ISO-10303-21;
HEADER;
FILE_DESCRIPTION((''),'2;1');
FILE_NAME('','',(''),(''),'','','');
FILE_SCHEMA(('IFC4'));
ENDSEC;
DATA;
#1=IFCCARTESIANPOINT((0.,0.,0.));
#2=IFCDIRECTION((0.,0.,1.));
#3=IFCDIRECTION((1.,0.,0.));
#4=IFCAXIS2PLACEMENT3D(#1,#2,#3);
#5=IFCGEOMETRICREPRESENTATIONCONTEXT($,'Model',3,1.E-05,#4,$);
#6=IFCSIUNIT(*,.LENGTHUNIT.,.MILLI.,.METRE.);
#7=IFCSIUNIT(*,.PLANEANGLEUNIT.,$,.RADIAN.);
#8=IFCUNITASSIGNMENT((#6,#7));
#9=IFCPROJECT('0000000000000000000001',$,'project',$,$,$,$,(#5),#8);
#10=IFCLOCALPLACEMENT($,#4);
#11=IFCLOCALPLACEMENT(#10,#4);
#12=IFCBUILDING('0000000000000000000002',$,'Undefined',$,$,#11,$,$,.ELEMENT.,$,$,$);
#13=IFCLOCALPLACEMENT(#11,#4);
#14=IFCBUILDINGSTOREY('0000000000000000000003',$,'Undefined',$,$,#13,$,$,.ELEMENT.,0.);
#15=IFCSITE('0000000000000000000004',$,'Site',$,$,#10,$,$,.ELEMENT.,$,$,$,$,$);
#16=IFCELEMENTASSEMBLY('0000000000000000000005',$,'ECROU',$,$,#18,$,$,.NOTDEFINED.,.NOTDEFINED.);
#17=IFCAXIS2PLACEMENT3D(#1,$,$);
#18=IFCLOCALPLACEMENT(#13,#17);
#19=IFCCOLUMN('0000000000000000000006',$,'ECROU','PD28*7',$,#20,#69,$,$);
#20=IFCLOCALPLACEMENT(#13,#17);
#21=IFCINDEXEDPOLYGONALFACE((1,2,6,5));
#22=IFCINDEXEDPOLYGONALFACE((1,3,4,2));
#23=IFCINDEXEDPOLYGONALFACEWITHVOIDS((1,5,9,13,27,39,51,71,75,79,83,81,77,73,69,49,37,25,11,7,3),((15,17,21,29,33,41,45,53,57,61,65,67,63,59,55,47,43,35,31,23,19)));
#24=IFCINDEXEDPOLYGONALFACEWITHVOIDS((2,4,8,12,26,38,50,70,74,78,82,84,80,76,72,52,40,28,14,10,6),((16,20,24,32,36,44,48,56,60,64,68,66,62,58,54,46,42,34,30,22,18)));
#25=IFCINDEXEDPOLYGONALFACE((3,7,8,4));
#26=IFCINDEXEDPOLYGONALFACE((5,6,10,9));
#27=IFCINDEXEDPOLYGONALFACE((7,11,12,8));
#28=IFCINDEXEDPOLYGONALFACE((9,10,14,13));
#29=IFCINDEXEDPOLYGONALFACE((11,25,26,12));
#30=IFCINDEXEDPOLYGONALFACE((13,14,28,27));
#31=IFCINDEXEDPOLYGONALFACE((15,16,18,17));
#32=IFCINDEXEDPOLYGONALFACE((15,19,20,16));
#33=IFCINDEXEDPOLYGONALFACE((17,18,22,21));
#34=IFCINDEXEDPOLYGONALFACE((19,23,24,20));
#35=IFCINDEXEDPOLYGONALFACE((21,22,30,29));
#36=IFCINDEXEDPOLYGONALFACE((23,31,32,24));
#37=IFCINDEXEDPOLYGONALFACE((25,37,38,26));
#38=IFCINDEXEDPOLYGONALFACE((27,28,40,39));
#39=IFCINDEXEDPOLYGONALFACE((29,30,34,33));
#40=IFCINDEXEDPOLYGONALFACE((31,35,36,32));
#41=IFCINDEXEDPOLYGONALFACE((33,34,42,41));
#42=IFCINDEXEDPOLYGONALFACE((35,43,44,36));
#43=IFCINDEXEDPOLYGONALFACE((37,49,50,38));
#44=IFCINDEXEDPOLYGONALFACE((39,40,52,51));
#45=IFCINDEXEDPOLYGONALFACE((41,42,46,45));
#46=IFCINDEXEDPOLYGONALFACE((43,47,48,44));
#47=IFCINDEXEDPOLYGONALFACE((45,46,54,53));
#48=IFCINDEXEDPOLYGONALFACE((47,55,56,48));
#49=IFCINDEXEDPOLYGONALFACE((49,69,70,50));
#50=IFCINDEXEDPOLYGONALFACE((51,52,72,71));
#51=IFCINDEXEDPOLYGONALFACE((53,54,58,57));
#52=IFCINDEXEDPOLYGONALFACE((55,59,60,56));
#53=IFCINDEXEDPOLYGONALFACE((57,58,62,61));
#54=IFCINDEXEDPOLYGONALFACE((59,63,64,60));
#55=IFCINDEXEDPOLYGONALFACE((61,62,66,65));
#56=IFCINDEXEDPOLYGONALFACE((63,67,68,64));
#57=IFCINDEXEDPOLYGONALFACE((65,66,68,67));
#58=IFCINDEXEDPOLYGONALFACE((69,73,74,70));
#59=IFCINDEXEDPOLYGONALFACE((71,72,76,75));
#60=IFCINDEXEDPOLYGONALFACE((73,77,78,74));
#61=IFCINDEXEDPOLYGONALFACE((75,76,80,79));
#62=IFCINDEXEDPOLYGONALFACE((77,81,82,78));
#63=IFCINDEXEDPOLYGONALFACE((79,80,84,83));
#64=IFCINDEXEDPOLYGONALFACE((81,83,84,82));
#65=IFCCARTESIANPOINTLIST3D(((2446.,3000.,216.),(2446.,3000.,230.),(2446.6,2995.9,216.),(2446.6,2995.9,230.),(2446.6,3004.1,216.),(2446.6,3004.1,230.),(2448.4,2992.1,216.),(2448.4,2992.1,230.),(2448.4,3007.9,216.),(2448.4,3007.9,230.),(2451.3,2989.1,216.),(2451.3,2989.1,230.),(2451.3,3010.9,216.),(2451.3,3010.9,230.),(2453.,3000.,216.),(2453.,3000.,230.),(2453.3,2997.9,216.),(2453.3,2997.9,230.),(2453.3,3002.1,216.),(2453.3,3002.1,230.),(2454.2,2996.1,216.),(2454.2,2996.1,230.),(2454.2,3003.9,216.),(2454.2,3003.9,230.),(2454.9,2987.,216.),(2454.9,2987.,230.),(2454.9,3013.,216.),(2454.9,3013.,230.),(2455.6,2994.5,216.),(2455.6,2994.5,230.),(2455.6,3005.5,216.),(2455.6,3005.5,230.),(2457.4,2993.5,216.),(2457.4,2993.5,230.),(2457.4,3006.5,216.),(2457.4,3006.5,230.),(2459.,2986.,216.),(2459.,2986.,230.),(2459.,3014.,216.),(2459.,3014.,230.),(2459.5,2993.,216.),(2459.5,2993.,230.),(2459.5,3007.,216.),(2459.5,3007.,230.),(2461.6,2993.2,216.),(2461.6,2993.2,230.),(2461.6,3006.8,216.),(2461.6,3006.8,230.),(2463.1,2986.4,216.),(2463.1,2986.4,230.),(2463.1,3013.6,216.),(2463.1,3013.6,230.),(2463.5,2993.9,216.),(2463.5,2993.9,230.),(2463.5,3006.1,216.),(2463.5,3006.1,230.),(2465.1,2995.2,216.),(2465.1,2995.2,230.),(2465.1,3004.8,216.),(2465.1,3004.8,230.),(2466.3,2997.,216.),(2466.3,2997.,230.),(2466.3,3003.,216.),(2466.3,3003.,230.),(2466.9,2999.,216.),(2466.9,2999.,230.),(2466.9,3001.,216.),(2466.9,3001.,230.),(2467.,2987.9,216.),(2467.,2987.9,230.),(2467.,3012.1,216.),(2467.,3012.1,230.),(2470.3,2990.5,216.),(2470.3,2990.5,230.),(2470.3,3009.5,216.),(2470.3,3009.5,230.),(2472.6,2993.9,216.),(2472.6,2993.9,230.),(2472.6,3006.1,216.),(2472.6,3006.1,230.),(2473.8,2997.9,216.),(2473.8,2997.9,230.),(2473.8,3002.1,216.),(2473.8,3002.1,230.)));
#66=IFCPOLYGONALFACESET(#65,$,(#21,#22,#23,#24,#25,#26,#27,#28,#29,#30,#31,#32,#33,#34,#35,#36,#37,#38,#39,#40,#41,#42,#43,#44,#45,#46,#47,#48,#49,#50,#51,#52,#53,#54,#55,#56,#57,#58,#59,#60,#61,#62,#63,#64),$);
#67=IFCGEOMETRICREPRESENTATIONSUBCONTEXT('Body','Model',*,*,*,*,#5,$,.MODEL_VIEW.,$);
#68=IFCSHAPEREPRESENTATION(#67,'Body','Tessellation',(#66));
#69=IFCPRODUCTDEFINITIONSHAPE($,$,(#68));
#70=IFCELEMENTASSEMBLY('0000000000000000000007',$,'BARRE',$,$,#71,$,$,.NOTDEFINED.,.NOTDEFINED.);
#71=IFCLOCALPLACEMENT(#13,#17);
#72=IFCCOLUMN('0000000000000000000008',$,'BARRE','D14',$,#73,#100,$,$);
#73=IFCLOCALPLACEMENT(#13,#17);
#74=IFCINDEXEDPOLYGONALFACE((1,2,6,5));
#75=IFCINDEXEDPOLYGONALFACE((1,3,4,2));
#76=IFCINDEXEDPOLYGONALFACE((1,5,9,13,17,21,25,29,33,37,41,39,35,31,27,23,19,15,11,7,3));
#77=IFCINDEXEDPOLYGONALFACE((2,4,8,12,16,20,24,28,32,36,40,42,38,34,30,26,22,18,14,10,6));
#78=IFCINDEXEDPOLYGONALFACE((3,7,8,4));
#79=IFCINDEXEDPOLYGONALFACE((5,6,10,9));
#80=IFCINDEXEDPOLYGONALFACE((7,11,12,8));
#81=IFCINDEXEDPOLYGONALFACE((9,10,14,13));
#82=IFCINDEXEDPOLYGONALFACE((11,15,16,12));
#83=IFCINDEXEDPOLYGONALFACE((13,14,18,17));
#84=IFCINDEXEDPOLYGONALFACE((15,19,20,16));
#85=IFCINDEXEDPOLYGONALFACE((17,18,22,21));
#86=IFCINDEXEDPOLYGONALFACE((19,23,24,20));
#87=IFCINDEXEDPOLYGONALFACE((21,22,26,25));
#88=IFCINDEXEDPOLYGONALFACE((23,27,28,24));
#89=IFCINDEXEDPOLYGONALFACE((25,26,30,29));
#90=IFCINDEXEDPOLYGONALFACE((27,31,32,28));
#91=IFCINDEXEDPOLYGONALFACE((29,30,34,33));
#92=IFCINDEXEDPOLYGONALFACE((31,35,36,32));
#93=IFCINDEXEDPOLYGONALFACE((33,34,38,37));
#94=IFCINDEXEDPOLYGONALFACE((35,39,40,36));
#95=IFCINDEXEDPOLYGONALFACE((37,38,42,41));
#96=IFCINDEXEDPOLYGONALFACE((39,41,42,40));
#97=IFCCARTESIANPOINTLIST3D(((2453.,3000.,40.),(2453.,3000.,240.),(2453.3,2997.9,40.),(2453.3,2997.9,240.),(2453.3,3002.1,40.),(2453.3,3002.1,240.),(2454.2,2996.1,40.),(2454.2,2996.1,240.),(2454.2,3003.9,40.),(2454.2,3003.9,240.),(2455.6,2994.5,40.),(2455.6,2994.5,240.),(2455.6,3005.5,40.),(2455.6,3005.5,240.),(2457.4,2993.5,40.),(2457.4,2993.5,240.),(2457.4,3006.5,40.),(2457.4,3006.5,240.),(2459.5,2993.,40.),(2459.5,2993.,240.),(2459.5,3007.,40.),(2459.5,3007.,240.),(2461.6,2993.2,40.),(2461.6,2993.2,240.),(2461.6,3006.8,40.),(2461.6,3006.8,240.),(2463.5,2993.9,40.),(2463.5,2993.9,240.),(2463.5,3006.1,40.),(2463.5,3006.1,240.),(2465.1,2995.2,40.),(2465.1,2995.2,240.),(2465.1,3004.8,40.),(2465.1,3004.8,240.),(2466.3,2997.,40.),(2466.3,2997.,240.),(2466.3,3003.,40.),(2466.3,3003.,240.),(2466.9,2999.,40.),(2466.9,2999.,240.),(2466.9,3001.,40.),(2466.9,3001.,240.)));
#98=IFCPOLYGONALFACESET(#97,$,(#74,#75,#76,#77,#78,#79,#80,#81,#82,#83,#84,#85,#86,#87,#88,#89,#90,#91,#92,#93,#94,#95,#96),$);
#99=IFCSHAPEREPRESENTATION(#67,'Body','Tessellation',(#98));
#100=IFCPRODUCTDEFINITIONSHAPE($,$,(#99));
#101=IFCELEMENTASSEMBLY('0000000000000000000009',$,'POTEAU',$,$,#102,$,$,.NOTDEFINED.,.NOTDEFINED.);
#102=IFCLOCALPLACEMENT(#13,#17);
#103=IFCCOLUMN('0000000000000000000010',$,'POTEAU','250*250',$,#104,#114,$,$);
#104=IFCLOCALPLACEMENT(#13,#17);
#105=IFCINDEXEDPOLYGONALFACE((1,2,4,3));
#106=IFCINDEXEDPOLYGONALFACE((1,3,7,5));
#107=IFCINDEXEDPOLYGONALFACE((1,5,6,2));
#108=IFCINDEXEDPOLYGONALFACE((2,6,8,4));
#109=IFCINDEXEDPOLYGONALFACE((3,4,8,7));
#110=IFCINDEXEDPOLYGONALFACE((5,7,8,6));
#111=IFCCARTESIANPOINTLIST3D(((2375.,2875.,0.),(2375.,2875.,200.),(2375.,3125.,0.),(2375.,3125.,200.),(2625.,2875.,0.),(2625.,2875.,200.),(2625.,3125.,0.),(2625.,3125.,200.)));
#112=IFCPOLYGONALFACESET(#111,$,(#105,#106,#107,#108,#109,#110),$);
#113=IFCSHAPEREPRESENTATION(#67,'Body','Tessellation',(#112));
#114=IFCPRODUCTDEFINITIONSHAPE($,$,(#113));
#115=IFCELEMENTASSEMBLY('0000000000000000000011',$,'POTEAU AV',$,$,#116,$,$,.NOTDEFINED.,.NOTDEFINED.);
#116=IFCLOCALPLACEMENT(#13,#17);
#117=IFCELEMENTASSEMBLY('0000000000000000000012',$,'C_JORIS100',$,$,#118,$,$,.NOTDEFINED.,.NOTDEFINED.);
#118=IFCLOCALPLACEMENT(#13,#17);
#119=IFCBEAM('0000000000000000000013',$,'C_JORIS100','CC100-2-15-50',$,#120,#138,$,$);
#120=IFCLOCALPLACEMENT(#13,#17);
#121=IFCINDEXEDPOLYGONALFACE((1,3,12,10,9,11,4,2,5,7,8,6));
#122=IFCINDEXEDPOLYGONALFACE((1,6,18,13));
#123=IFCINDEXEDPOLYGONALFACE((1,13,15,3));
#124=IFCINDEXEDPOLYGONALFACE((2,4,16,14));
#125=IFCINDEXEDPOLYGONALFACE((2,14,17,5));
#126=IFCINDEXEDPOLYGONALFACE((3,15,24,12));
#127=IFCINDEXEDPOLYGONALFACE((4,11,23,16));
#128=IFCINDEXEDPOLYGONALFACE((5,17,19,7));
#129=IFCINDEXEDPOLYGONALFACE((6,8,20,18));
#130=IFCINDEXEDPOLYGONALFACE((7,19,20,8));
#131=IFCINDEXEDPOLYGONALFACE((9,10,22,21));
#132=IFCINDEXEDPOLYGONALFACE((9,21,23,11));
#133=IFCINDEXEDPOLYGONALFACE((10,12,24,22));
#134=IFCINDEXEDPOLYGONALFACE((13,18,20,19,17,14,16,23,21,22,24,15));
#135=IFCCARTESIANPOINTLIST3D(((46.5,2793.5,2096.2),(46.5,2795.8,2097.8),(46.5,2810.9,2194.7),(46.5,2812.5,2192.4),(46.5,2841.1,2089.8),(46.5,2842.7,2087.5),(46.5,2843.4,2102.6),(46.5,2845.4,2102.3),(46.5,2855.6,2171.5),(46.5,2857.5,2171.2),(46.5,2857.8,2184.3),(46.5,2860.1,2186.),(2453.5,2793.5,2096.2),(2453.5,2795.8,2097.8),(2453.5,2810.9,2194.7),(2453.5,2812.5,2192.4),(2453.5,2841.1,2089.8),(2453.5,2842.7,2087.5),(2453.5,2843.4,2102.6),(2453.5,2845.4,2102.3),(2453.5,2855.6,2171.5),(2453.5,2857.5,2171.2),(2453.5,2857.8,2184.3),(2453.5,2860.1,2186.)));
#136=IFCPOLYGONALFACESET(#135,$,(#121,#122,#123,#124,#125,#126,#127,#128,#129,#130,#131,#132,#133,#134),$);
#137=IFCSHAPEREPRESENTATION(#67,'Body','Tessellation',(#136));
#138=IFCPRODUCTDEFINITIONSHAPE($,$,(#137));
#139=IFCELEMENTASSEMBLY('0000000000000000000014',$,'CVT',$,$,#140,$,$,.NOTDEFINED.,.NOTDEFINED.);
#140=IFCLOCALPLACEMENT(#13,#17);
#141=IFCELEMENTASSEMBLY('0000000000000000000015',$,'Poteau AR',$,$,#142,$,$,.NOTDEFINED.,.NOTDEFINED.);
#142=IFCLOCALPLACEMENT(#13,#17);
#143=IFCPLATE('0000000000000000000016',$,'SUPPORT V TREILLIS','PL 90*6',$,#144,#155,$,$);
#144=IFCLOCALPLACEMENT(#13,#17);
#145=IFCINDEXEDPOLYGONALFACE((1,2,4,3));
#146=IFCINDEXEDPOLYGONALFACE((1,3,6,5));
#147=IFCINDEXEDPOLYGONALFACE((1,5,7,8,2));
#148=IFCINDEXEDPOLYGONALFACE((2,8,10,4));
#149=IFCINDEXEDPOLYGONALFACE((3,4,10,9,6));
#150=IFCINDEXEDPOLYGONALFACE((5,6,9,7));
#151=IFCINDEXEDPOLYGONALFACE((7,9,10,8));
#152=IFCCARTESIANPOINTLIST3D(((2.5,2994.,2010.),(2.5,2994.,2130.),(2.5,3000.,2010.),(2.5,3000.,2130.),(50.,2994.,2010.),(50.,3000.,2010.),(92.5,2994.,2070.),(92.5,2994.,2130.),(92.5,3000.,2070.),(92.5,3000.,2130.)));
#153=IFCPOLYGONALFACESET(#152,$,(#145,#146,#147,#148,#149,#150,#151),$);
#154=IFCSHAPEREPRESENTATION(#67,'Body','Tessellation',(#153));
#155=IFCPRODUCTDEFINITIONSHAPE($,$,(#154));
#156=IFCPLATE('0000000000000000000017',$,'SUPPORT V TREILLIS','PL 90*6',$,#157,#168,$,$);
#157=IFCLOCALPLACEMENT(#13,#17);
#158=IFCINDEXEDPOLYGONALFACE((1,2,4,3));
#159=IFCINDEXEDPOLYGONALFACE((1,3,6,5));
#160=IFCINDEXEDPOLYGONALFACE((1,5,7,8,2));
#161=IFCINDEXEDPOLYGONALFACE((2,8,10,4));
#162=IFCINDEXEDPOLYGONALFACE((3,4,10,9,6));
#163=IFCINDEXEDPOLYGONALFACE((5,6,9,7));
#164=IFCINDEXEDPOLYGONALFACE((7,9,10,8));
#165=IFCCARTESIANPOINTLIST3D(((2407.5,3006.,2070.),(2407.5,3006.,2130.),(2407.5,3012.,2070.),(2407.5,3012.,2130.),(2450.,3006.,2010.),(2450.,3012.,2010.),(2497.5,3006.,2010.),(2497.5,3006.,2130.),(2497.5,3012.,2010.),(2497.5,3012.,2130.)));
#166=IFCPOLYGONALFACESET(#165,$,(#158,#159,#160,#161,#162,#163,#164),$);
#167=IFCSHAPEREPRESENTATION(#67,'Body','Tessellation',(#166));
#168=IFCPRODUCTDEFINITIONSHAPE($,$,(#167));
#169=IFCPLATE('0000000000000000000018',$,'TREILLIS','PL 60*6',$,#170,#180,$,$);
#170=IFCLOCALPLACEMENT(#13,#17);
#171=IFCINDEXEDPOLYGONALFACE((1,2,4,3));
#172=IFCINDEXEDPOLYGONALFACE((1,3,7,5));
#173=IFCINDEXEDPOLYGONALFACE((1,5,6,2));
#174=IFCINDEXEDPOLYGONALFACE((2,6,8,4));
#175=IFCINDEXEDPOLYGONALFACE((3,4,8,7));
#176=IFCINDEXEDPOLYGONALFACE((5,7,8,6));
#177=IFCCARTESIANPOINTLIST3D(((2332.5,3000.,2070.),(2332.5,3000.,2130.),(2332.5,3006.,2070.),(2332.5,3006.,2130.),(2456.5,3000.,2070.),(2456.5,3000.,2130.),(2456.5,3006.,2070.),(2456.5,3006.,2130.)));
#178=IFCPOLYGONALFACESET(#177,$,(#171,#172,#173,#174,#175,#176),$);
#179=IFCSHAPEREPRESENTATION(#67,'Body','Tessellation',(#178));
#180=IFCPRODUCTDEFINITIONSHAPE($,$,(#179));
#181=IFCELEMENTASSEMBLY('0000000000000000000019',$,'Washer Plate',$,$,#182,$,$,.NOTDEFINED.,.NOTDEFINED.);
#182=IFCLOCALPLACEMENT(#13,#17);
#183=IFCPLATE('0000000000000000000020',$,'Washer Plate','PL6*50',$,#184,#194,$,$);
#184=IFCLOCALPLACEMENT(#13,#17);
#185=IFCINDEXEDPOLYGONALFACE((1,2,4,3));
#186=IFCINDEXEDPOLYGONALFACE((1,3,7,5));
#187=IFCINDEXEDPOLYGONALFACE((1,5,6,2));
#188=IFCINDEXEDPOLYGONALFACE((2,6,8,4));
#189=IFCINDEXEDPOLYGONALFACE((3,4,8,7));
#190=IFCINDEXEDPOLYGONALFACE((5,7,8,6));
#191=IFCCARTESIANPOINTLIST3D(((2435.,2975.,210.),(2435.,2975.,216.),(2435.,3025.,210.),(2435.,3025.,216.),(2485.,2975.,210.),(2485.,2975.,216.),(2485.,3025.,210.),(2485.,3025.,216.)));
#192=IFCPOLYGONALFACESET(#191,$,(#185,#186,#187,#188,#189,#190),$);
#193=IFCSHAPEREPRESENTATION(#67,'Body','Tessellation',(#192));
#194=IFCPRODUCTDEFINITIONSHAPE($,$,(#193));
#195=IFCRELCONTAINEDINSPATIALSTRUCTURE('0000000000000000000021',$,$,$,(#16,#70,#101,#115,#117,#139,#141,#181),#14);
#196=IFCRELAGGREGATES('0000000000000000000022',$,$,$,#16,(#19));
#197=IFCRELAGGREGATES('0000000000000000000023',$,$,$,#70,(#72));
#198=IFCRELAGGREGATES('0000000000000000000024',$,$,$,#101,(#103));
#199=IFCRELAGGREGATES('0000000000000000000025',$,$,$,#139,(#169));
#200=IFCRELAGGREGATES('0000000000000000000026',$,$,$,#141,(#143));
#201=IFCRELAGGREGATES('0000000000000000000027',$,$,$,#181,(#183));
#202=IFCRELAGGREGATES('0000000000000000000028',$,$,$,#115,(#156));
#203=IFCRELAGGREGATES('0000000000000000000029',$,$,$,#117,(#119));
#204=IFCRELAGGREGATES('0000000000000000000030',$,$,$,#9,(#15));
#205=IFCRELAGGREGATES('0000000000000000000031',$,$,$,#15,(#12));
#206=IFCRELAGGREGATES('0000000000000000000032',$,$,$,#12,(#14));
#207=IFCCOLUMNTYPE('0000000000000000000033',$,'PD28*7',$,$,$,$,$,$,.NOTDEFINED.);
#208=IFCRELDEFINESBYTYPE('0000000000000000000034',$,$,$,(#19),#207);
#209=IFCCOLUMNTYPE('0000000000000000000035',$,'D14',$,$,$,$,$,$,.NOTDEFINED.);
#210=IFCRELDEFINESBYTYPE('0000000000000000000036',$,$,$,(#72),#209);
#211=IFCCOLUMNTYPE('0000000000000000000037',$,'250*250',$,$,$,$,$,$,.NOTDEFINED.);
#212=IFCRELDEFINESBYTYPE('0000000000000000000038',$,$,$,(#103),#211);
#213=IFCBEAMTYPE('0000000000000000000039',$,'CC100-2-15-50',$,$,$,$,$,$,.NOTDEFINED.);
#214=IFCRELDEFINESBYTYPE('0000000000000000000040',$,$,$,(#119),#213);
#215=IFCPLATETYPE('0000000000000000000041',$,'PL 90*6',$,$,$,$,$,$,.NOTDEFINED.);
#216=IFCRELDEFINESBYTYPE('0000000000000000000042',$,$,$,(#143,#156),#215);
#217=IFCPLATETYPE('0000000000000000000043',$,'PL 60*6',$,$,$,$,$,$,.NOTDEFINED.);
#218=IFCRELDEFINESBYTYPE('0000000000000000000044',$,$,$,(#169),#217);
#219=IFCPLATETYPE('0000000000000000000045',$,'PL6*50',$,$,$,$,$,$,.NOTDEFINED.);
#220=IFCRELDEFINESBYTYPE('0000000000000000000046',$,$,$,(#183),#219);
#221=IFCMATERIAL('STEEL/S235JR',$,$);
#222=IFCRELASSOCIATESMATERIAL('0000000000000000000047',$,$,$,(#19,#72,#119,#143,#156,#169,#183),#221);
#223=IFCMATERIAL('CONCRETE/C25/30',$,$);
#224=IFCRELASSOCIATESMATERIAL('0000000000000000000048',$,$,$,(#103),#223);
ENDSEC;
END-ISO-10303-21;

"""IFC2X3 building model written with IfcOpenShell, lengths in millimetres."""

from ifc_helpers import new_model, si_unit, frame, origin_with_axes, origin_2d_with_axis, place, context, subcontext, project, spatial, polyline, rectangle, circle, hollow_circle, c_section, outline, extrude, clip, halfspace, material, type_object, element, aggregate, save


model = new_model("IFC2X3")

# Units and contexts
model_context = context("Model", 3, precision=1e-05, world=origin_with_axes())
body_context = subcontext(model_context, "Body", "Model", "MODEL_VIEW")
ifc_project = project(units=[si_unit("LENGTHUNIT", "METRE", prefix="MILLI"), si_unit("PLANEANGLEUNIT", "RADIAN")], contexts=[model_context])

# Site, building, storey
site_placement = place(None, origin_with_axes())
site = spatial("IfcSite", under=ifc_project, at=site_placement, Name="Site", CompositionType="ELEMENT")
building_placement = place(site_placement, origin_with_axes())
building = spatial("IfcBuilding", under=site, at=building_placement, Name="Undefined", CompositionType="ELEMENT")
storey_placement = place(building_placement, origin_with_axes())
storey = spatial("IfcBuildingStorey", under=building, at=storey_placement, Name="Undefined", CompositionType="ELEMENT", Elevation=0.0)

# Element assemblies, columns
assembly_1_placement = place(storey_placement, origin_with_axes())
assembly_1 = element("IfcElementAssembly", 1, at=assembly_1_placement, inside=storey, Name="ECROU", AssemblyPlace="NOTDEFINED", PredefinedType="NOTDEFINED")
ifc_material_1 = material(Name="STEEL/S235JR")
column_type_1 = type_object("IfcColumnType", Name="PD28*7", PredefinedType="NOTDEFINED")
column_1_placement = place(assembly_1_placement, frame((2460.0, 3000.0, 230.0), z_axis=(0.0, 0.0, -1.0), x_axis=(0.0, -1.0, 0.0)))
column_1 = element("IfcColumn", 2, at=column_1_placement, type_object=column_type_1, material=ifc_material_1, Name="ECROU", Description="PD28*7", context=body_context, shape_type="SweptSolid", body=[
    extrude(hollow_circle(Radius=14.0, WallThickness=7.0, at=origin_2d_with_axis()), frame((0.0, 0.0, 14.0), z_axis=(0.0, 0.0, -1.0), x_axis=(0.0, 1.0, 0.0)), (0.0, 0.0, 1.0), 14.0),
])
aggregate(assembly_1, [column_1])
assembly_2_placement = place(storey_placement, origin_with_axes())
assembly_2 = element("IfcElementAssembly", 3, at=assembly_2_placement, inside=storey, Name="BARRE", AssemblyPlace="NOTDEFINED", PredefinedType="NOTDEFINED")
column_type_2 = type_object("IfcColumnType", Name="D14", PredefinedType="NOTDEFINED")
column_2_placement = place(assembly_2_placement, frame((2460.0, 3000.0, 240.0), z_axis=(0.0, 0.0, -1.0), x_axis=(0.0, -1.0, 0.0)))
column_2 = element("IfcColumn", 4, at=column_2_placement, type_object=column_type_2, material=ifc_material_1, Name="BARRE", Description="D14", context=body_context, shape_type="SweptSolid", body=[
    extrude(circle(Radius=7.0, at=origin_2d_with_axis()), frame((0.0, 0.0, 200.0), z_axis=(0.0, 0.0, -1.0), x_axis=(0.0, 1.0, 0.0)), (0.0, 0.0, 1.0), 200.0),
])
aggregate(assembly_2, [column_2])
assembly_3_placement = place(storey_placement, origin_with_axes())
assembly_3 = element("IfcElementAssembly", 5, at=assembly_3_placement, inside=storey, Name="POTEAU", AssemblyPlace="NOTDEFINED", PredefinedType="NOTDEFINED")
ifc_material_2 = material(Name="CONCRETE/C25/30")
column_type_3 = type_object("IfcColumnType", Name="250*250", PredefinedType="NOTDEFINED")
column_3_placement = place(assembly_3_placement, frame((2500.0, 3000.0, 0.0), z_axis=(0.0, 0.0, 1.0), x_axis=(0.0, 1.0, 0.0)))
column_3 = element("IfcColumn", 6, at=column_3_placement, type_object=column_type_3, material=ifc_material_2, Name="POTEAU", Description="250*250", context=body_context, shape_type="SweptSolid", body=[
    extrude(rectangle(XDim=250.0, YDim=250.0, at=origin_2d_with_axis()), frame((0.0, 0.0, 200.0), z_axis=(0.0, 0.0, -1.0), x_axis=(0.0, 1.0, 0.0)), (0.0, 0.0, 1.0), 200.0),
])
aggregate(assembly_3, [column_3])
assembly_4_placement = place(storey_placement, origin_with_axes())
assembly_4 = element("IfcElementAssembly", 7, at=assembly_4_placement, inside=storey, Name="POTEAU AV", AssemblyPlace="NOTDEFINED", PredefinedType="NOTDEFINED")

# Element assemblies, beam
assembly_5_placement = place(storey_placement, origin_with_axes())
assembly_5 = element("IfcElementAssembly", 8, at=assembly_5_placement, inside=storey, Name="C_JORIS100", AssemblyPlace="NOTDEFINED", PredefinedType="NOTDEFINED")
beam_type_1 = type_object("IfcBeamType", Name="CC100-2-15-50", PredefinedType="NOTDEFINED")
beam_1_placement = place(assembly_5_placement, frame((2500.0, 2826.8, 2141.1), z_axis=(0.0, 0.173992, 0.984747), x_axis=(-1.0, 0.0, 0.0)))
beam_1 = element("IfcBeam", 9, at=beam_1_placement, type_object=beam_type_1, material=ifc_material_1, Name="C_JORIS100", Description="CC100-2-15-50", context=body_context, shape_type="Clipping", body=[
    clip(clip(extrude(c_section(Depth=100.0, Width=50.0, WallThickness=2.0, Girth=15.0, at=origin_2d_with_axis()), frame((2500.0, 0.0, 0.0), z_axis=(-1.0, 0.0, 0.0), x_axis=(0.0, -1.0, 0.0)), (0.0, 0.0, 1.0), 2500.0), halfspace(frame((2453.5, 23.9, 50.0), z_axis=(1.0, 0.0, 0.0), x_axis=(0.0, 0.000028, -1.0)), False)), halfspace(frame((46.5, 23.0, 50.0), z_axis=(-1.0, 0.0, 0.0), x_axis=(0.0, 0.000028, -1.0)), False)),
])
assembly_6_placement = place(storey_placement, origin_with_axes())
assembly_6 = element("IfcElementAssembly", 10, at=assembly_6_placement, inside=storey, Name="CVT", AssemblyPlace="NOTDEFINED", PredefinedType="NOTDEFINED")

# Element assembly, plate
assembly_7_placement = place(storey_placement, origin_with_axes())
assembly_7 = element("IfcElementAssembly", 11, at=assembly_7_placement, inside=storey, Name="Poteau AR", AssemblyPlace="NOTDEFINED", PredefinedType="NOTDEFINED")
plate_type_1 = type_object("IfcPlateType", Name="PL 90*6", PredefinedType="NOTDEFINED")
plate_1_placement = place(assembly_7_placement, frame((47.5, 2997.0, 2130.0), z_axis=(0.0, -1.0, 0.0), x_axis=(0.0, 0.0, -1.0)))
plate_1 = element("IfcPlate", 12, at=plate_1_placement, type_object=plate_type_1, material=ifc_material_1, Name="SUPPORT V TREILLIS", Description="PL 90*6", context=body_context, shape_type="Clipping", body=[
    clip(extrude(outline(polyline([(120.0, -45.0), (0.0, -45.0), (0.0, 45.0), (60.0, 45.0), (120.0, 2.5), (120.0, -45.0)])), frame((0.0, 0.0, -3.0), z_axis=(0.0, 0.0, 1.0), x_axis=(1.0, 0.0, 0.0)), (0.0, 0.0, 1.0), 6.0), halfspace(frame((187.1, -45.0, 3.0), z_axis=(0.578017, 0.816024, 0.0), x_axis=(-0.816024, 0.578017, 0.0)), False)),
])

# Plates
plate_2_placement = place(assembly_4_placement, frame((2452.5, 3009.0, 2130.0), z_axis=(0.0, 1.0, 0.0), x_axis=(0.0, 0.0, -1.0)))
plate_2 = element("IfcPlate", 13, at=plate_2_placement, type_object=plate_type_1, material=ifc_material_1, Name="SUPPORT V TREILLIS", Description="PL 90*6", context=body_context, shape_type="Clipping", body=[
    clip(extrude(outline(polyline([(120.0, 2.5), (120.0, -45.0), (0.0, -45.0), (0.0, 45.0), (60.0, 45.0), (120.0, 2.5)])), frame((0.0, 0.0, -3.0), z_axis=(0.0, 0.0, 1.0), x_axis=(1.0, 0.0, 0.0)), (0.0, 0.0, 1.0), 6.0), halfspace(frame((187.1, -45.0, 3.0), z_axis=(0.578017, 0.816024, 0.0), x_axis=(-0.816024, 0.578017, 0.0)), False)),
])
plate_type_2 = type_object("IfcPlateType", Name="PL 60*6", PredefinedType="NOTDEFINED")
plate_3_placement = place(assembly_6_placement, frame((2456.5, 3003.0, 2100.0), z_axis=(0.0, 1.0, 0.0), x_axis=(-1.0, 0.0, 0.0)))
plate_3 = element("IfcPlate", 14, at=plate_3_placement, type_object=plate_type_2, material=ifc_material_1, Name="TREILLIS", Description="PL 60*6", context=body_context, shape_type="SweptSolid", body=[
    extrude(outline(polyline([(124.0, -30.0), (0.0, -30.0), (0.0, 30.0), (124.0, 30.0), (124.0, -30.0)])), frame((0.0, 0.0, -3.0), z_axis=(0.0, 0.0, 1.0), x_axis=(1.0, 0.0, 0.0)), (0.0, 0.0, 1.0), 6.0),
])
aggregate(assembly_6, [plate_3])

# Element assembly, plate
assembly_8_placement = place(storey_placement, origin_with_axes())
assembly_8 = element("IfcElementAssembly", 15, at=assembly_8_placement, inside=storey, Name="Washer Plate", AssemblyPlace="NOTDEFINED", PredefinedType="NOTDEFINED")
plate_type_3 = type_object("IfcPlateType", Name="PL6*50", PredefinedType="NOTDEFINED")
plate_4_placement = place(assembly_8_placement, frame((2485.0, 3025.0, 213.0), z_axis=(0.0, 0.0, -1.0), x_axis=(0.0, -1.0, 0.0)))
plate_4 = element("IfcPlate", 16, at=plate_4_placement, type_object=plate_type_3, material=ifc_material_1, Name="Washer Plate", Description="PL6*50", context=body_context, shape_type="SweptSolid", body=[
    extrude(outline(polyline([(0.0, 0.0), (50.0, 0.0), (50.0, 50.0), (0.0, 50.0), (0.0, 0.0)])), frame((0.0, 0.0, -3.0), z_axis=(0.0, 0.0, 1.0), x_axis=(1.0, 0.0, 0.0)), (0.0, 0.0, 1.0), 6.0),
])

aggregate(assembly_7, [plate_1])
aggregate(assembly_8, [plate_4])
aggregate(assembly_4, [plate_2])

aggregate(assembly_5, [beam_1])

save(model, "model.ifc")
